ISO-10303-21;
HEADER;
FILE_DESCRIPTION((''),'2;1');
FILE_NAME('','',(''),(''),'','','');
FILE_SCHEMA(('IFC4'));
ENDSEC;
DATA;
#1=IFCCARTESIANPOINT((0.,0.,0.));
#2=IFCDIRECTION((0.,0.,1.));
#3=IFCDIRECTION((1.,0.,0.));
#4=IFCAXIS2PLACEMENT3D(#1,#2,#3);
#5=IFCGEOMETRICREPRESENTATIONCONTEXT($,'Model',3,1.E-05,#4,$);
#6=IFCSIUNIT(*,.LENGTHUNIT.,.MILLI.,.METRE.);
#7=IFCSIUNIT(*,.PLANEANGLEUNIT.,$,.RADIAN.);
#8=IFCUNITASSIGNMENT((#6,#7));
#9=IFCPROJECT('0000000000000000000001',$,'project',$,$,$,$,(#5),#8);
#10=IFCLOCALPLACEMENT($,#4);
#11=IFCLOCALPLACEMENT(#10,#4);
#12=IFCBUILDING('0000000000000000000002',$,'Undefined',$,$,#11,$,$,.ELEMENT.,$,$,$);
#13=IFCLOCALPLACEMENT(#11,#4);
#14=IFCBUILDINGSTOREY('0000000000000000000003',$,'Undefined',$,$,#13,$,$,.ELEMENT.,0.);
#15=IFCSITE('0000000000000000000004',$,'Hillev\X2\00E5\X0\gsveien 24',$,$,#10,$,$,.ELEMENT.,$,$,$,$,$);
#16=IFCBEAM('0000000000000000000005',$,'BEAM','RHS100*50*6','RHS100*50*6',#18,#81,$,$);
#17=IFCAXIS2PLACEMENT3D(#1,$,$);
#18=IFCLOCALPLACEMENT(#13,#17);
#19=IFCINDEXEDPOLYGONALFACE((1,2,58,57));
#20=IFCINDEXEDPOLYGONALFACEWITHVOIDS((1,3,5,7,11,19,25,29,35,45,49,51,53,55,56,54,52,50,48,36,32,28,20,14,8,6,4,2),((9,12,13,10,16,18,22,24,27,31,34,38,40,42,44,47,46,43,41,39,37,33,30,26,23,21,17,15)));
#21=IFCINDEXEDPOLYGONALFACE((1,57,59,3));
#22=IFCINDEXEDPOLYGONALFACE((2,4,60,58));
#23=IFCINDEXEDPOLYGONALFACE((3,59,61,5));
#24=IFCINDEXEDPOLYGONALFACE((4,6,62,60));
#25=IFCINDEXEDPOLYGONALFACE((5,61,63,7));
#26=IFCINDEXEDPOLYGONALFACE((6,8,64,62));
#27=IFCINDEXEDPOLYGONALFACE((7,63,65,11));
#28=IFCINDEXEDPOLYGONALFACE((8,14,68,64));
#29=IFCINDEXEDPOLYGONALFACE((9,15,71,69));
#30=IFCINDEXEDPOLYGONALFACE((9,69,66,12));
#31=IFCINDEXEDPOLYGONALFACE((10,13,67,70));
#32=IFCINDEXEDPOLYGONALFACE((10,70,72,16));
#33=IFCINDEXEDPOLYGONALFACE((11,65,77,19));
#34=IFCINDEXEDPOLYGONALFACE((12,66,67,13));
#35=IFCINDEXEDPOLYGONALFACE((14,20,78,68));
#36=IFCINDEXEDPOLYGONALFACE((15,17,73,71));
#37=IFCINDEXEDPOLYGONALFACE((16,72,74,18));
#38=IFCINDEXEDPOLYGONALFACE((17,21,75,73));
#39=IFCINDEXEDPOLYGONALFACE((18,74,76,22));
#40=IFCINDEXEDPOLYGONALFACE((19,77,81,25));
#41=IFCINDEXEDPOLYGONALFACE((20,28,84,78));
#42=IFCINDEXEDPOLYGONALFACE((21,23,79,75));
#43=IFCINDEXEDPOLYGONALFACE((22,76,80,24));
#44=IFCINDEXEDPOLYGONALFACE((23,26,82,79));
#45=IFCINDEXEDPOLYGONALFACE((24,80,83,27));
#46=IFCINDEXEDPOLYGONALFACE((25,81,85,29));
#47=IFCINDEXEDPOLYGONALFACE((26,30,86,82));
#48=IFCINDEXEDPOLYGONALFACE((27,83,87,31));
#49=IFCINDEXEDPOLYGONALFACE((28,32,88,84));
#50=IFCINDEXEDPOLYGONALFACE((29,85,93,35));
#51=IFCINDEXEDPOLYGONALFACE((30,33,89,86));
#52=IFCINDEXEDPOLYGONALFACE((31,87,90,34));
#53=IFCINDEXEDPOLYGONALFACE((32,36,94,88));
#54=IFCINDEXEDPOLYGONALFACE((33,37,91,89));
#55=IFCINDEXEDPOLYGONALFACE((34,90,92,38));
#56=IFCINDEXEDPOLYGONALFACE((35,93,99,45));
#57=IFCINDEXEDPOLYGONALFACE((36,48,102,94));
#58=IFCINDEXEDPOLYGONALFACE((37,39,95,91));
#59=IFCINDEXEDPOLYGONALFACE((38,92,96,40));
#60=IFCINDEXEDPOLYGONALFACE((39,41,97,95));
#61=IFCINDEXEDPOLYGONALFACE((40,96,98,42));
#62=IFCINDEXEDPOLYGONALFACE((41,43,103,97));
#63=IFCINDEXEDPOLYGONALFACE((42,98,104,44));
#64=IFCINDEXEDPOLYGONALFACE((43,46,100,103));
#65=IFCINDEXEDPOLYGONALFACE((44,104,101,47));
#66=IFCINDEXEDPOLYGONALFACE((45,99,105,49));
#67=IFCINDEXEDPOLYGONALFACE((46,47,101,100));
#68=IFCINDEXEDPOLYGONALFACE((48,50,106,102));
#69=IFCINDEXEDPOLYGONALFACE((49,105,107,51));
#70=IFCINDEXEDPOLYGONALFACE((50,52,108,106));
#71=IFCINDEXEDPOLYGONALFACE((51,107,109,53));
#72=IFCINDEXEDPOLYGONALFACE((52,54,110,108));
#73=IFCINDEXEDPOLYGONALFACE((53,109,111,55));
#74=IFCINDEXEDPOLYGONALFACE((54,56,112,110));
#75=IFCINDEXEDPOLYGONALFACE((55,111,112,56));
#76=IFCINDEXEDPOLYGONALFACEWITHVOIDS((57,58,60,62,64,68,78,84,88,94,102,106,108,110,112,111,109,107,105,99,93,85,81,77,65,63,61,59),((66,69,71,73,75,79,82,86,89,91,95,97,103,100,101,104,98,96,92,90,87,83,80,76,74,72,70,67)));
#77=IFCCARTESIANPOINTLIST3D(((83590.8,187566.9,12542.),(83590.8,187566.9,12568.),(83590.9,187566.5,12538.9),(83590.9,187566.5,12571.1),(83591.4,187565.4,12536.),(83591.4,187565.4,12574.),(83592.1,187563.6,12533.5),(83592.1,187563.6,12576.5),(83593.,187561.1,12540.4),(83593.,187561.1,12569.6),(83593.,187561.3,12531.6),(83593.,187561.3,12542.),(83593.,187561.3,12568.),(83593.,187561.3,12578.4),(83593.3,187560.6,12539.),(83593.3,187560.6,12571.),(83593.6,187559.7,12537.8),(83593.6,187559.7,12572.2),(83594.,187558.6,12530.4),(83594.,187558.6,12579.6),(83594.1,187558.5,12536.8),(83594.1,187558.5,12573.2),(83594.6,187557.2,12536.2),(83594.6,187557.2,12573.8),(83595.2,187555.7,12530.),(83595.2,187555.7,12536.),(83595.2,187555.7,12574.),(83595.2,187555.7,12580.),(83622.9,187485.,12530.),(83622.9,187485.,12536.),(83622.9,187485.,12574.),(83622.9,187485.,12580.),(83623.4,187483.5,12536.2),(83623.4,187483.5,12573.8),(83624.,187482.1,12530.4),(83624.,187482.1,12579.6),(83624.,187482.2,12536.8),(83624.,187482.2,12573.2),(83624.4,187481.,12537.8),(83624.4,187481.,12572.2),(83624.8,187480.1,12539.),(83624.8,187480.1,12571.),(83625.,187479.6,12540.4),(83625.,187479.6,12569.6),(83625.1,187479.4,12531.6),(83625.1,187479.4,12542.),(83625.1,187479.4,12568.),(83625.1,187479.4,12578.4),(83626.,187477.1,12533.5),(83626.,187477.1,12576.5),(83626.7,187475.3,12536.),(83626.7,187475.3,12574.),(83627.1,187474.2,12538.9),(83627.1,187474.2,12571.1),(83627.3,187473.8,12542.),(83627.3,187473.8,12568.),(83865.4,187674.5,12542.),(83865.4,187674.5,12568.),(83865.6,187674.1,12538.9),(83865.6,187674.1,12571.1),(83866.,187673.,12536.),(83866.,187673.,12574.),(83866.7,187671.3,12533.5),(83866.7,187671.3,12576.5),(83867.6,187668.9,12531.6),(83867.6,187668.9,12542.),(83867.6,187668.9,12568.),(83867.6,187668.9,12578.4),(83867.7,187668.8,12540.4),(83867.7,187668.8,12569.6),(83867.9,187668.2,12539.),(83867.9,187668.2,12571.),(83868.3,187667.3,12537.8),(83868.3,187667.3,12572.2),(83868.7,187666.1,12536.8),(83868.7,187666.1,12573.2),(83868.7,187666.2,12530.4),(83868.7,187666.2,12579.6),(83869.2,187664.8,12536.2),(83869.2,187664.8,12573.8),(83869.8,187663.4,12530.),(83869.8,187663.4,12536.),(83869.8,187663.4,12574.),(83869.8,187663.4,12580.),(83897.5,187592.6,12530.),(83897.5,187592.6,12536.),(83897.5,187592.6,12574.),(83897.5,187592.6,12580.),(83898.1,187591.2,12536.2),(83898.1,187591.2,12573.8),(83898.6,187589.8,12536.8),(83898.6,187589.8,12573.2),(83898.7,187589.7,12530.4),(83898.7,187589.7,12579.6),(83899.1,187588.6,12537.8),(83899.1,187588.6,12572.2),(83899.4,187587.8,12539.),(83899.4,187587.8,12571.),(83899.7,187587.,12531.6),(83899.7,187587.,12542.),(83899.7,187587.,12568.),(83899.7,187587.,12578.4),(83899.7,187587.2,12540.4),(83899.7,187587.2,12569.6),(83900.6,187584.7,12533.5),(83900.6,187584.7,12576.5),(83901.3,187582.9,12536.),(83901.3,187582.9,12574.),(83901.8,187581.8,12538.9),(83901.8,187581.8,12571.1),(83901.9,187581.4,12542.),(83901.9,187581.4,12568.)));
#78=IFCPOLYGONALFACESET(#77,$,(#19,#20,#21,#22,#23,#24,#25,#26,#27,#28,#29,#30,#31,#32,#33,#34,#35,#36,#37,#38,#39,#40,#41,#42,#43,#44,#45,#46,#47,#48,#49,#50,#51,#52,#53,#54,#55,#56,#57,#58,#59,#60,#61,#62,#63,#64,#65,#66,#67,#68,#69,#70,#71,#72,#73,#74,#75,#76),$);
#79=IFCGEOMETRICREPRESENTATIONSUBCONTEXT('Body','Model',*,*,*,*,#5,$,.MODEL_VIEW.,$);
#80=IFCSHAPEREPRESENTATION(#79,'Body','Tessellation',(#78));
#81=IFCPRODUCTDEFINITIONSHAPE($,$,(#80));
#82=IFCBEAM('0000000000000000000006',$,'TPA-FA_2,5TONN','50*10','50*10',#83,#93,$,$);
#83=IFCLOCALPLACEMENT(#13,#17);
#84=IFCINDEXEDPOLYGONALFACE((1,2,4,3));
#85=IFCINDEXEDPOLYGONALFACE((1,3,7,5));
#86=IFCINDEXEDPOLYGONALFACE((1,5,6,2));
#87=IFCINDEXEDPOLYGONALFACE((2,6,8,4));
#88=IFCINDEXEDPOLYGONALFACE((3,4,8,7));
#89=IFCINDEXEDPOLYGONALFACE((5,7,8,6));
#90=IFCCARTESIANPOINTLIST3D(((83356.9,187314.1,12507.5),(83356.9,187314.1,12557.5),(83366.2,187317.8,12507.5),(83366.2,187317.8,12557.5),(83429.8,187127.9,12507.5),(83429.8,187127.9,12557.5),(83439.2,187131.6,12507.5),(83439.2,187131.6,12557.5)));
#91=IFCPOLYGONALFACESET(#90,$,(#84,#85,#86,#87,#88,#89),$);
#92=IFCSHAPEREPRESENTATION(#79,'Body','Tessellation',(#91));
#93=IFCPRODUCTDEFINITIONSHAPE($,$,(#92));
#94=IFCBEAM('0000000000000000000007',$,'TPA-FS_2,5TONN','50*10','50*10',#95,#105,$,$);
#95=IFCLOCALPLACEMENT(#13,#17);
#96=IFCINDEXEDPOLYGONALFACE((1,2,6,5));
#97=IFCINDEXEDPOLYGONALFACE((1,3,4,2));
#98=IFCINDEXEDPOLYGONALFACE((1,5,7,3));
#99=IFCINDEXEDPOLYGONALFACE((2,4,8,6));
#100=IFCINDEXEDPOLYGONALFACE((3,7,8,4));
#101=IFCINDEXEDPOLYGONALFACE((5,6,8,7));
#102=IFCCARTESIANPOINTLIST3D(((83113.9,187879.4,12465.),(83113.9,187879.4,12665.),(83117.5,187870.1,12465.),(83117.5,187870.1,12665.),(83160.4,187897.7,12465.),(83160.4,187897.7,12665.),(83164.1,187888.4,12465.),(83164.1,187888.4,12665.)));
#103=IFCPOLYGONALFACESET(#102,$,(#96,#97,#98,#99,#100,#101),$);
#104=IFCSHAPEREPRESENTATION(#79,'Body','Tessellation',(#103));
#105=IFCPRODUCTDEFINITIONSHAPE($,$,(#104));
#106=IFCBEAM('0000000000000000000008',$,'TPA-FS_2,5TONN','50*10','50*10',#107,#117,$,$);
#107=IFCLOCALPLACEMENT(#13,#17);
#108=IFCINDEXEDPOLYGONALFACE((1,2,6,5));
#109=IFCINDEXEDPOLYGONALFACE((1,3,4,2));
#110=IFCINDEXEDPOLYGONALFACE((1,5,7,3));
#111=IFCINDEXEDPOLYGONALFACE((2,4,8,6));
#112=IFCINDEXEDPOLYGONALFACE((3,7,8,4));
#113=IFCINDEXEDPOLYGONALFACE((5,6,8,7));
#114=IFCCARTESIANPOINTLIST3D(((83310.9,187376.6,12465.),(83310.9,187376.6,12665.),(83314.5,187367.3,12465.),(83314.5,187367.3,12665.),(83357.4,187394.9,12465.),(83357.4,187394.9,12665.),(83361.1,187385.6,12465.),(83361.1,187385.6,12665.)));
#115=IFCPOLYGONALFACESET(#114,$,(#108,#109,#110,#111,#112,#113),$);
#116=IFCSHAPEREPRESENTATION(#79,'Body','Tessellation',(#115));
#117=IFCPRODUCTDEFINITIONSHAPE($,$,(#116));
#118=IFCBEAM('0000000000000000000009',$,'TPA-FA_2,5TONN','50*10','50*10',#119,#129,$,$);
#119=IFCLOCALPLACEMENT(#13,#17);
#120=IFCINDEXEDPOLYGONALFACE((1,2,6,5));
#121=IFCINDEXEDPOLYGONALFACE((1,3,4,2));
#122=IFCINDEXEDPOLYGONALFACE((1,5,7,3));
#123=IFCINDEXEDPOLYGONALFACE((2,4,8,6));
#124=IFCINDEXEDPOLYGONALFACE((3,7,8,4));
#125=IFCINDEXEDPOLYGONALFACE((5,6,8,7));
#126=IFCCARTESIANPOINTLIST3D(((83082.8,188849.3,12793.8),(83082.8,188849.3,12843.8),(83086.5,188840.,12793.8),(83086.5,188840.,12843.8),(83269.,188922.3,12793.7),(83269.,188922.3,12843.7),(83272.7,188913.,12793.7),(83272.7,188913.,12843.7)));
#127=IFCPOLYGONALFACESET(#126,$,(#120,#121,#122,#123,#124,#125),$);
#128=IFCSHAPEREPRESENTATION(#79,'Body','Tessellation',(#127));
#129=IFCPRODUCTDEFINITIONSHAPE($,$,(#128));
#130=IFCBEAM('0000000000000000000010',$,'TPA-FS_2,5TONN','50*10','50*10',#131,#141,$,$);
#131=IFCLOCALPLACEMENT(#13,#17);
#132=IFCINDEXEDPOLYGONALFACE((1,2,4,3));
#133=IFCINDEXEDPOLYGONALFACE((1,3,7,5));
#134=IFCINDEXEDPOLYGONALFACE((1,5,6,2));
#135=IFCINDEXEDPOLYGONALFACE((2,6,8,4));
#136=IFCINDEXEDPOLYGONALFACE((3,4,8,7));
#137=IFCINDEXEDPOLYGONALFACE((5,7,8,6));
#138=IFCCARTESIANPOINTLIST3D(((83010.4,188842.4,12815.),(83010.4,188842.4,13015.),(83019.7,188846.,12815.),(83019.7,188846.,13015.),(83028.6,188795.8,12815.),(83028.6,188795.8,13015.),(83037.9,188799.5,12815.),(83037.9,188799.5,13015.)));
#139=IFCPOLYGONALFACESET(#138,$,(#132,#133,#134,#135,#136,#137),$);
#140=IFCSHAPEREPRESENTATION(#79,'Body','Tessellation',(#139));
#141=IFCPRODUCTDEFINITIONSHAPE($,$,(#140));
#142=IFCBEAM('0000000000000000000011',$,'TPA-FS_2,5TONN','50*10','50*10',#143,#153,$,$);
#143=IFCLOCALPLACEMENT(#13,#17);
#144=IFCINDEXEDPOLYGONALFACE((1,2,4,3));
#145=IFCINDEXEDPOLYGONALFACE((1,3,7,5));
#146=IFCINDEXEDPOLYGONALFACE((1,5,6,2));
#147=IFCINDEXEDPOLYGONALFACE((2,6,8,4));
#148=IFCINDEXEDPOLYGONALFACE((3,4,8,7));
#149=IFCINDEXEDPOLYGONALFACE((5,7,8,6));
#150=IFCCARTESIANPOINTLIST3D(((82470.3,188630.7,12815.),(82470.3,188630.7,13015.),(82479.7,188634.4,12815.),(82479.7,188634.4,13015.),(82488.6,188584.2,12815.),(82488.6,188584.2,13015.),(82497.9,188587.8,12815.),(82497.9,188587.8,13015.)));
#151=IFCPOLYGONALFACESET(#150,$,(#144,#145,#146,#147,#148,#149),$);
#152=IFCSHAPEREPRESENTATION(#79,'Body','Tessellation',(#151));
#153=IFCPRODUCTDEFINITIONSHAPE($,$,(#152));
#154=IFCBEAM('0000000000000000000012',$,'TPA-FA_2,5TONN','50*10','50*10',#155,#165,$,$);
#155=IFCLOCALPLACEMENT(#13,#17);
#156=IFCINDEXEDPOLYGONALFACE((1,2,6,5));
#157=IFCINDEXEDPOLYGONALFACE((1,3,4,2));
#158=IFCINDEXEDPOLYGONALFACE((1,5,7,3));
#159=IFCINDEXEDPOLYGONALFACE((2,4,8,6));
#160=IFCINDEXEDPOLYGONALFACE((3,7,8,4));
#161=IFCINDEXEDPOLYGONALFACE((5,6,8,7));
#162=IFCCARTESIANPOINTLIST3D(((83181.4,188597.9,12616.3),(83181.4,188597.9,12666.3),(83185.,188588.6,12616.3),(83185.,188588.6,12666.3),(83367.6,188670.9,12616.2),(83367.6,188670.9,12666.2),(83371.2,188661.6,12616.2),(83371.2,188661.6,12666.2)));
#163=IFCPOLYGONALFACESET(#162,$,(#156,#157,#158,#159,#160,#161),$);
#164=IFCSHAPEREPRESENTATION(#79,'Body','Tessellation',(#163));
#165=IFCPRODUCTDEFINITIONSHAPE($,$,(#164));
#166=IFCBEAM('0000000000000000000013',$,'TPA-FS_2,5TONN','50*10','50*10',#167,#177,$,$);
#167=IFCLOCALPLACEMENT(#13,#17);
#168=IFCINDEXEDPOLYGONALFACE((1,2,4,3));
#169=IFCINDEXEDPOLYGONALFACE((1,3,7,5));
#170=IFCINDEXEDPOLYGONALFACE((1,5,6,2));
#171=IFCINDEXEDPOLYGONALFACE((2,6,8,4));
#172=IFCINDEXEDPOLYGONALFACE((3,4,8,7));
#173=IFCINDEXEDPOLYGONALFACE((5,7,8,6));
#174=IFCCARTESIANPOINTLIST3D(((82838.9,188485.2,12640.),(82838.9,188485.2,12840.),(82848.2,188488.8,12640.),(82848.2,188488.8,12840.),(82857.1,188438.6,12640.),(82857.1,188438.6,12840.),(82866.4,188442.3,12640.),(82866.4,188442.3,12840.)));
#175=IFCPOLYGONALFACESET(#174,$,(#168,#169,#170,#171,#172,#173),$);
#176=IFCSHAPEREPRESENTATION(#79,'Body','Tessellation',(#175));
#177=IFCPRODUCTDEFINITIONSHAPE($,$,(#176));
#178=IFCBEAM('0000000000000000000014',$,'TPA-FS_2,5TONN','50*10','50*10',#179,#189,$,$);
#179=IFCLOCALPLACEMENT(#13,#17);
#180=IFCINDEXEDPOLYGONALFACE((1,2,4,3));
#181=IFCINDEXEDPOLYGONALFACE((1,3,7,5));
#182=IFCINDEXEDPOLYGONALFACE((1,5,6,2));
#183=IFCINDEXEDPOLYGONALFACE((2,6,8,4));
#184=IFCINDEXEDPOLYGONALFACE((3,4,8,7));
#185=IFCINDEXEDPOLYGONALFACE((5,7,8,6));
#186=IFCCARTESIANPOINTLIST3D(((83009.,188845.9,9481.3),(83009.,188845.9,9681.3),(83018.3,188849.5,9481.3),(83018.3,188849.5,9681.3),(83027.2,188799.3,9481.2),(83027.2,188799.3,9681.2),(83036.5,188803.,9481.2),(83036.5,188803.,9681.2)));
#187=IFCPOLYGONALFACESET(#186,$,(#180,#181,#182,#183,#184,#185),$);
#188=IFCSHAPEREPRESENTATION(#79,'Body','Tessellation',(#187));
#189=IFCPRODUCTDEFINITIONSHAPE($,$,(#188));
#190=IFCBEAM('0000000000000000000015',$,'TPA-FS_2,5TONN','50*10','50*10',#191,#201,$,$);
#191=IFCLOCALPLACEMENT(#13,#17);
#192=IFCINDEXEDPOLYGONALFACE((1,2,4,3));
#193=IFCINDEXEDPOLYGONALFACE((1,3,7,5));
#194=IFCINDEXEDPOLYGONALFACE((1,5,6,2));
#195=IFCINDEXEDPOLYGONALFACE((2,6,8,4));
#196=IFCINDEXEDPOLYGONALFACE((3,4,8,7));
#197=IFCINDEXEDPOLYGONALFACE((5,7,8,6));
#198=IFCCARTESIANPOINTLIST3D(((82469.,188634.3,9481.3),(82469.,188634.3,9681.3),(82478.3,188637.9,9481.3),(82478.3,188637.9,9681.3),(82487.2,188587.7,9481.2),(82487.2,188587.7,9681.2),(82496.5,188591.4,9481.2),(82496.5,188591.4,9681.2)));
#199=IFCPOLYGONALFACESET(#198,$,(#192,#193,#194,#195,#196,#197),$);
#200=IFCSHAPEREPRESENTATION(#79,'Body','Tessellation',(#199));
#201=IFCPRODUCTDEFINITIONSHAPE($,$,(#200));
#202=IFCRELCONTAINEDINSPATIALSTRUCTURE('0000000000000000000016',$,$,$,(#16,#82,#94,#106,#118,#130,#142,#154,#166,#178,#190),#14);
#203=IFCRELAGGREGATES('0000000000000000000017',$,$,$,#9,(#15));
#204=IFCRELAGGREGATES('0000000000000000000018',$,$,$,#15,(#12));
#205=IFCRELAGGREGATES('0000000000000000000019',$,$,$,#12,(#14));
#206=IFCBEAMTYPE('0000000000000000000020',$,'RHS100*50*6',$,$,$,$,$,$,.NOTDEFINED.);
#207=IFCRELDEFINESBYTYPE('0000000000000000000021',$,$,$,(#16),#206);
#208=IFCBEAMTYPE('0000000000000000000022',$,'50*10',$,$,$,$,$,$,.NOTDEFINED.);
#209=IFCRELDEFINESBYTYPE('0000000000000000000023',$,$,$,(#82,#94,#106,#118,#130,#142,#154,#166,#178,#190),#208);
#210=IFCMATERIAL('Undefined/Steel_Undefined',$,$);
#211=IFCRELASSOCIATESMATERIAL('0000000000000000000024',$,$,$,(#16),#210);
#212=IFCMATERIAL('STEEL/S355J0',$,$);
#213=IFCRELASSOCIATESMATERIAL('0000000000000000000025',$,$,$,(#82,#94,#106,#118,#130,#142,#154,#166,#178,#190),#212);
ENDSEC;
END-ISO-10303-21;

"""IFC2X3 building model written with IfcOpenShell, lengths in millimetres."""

from ifc_helpers import new_model, si_unit, frame, frame_2d, origin_with_axes, place, context, subcontext, project, spatial, rectangle, hollow_rectangle, extrude, material, type_object, element, save


model = new_model("IFC2X3")

# Units and contexts
model_context = context("Model", 3, precision=1e-05, world=origin_with_axes())
body_context = subcontext(model_context, "Body", "Model", "MODEL_VIEW")
ifc_project = project(units=[si_unit("LENGTHUNIT", "METRE", prefix="MILLI"), si_unit("PLANEANGLEUNIT", "RADIAN")], contexts=[model_context])

# Site, building, storey
site_placement = place(None, origin_with_axes())
site = spatial("IfcSite", under=ifc_project, at=site_placement, Name="Hillevågsveien 24", CompositionType="ELEMENT")
building_placement = place(site_placement, origin_with_axes())
building = spatial("IfcBuilding", under=site, at=building_placement, Name="Undefined", CompositionType="ELEMENT")
storey_placement = place(building_placement, origin_with_axes())
storey = spatial("IfcBuildingStorey", under=building, at=storey_placement, Name="Undefined", CompositionType="ELEMENT", Elevation=0.0)

# Beams
ifc_material_1 = material(Name="Undefined/Steel_Undefined")
beam_type_1 = type_object("IfcBeamType", Name="RHS100*50*6", PredefinedType="NOTDEFINED")
for number, where, z_axis, x_axis, name in (
    (1, (83883.7, 187628.0, 12555.0), (0.364877, -0.931056, 0.0), (-0.931056, -0.364877, 0.0), "BEAM"),
):
    element("IfcBeam", number, at=place(storey_placement, frame(where, z_axis=z_axis, x_axis=x_axis)), inside=storey, type_object=beam_type_1, material=ifc_material_1, Name=name, Description="RHS100*50*6", ObjectType="RHS100*50*6", context=body_context, shape_type="SweptSolid", body=[
        extrude(hollow_rectangle(XDim=50.0, YDim=100.0, WallThickness=6.0, InnerFilletRadius=6.0, OuterFilletRadius=12.0, at=frame_2d((0.0, 0.0), x_axis=(1.0, 0.0))), frame((295.0, 0.0, 0.0), z_axis=(-1.0, 0.0, 0.0), x_axis=(0.0, -1.0, 0.0)), (0.0, 0.0, 1.0), 295.0),
    ])
ifc_material_2 = material(Name="STEEL/S355J0")
beam_type_2 = type_object("IfcBeamType", Name="50*10", PredefinedType="NOTDEFINED")
beam_1_placement = place(storey_placement, frame((83434.5, 187129.7, 12532.5), z_axis=(-0.000005, 0.000012, 1.0), x_axis=(-0.364877, 0.931056, -0.000013)))
element("IfcBeam", 2, at=beam_1_placement, inside=storey, type_object=beam_type_2, material=ifc_material_2, Name="TPA-FA_2,5TONN", Description="50*10", ObjectType="50*10", context=body_context, shape_type="SweptSolid", body=[
    extrude(rectangle(XDim=10.0, YDim=50.0, at=frame_2d((0.0, 0.0), x_axis=(1.0, 0.0))), frame((200.0, 0.0, 0.0), z_axis=(-1.0, 0.0, 0.0), x_axis=(0.0, -1.0, 0.0)), (0.0, 0.0, 1.0), 200.0),
])
for number, where, z_axis, x_axis, name in (
    (3, (83139.0, 187883.9, 12665.0), (0.931056, 0.364877, 0.0), (0.0, 0.0, -1.0), "TPA-FS_2,5TONN"),
    (4, (83336.0, 187381.1, 12665.0), (0.931056, 0.364877, 0.0), (0.0, 0.0, -1.0), "TPA-FS_2,5TONN"),
):
    element("IfcBeam", number, at=place(storey_placement, frame(where, z_axis=z_axis, x_axis=x_axis)), inside=storey, type_object=beam_type_2, material=ifc_material_2, Name=name, Description="50*10", ObjectType="50*10", context=body_context, shape_type="SweptSolid", body=[
        extrude(rectangle(XDim=10.0, YDim=50.0, at=frame_2d((0.0, 0.0), x_axis=(1.0, 0.0))), frame((200.0, 0.0, 0.0), z_axis=(-1.0, 0.0, 0.0), x_axis=(0.0, -1.0, 0.0)), (0.0, 0.0, 1.0), 200.0),
    ])
beam_2_placement = place(storey_placement, frame((83270.9, 188917.6, 12818.7), z_axis=(0.000001, 0.0, 1.0), x_axis=(-0.931056, -0.364877, 0.000001)))
element("IfcBeam", 5, at=beam_2_placement, inside=storey, type_object=beam_type_2, material=ifc_material_2, Name="TPA-FA_2,5TONN", Description="50*10", ObjectType="50*10", context=body_context, shape_type="SweptSolid", body=[
    extrude(rectangle(XDim=10.0, YDim=50.0, at=frame_2d((0.0, 0.0), x_axis=(1.0, 0.0))), frame((200.0, 0.0, 0.0), z_axis=(-1.0, 0.0, 0.0), x_axis=(0.0, -1.0, 0.0)), (0.0, 0.0, 1.0), 200.0),
])
for number, where, z_axis, x_axis, name in (
    (6, (83024.1, 188820.9, 13015.0), (-0.364877, 0.931056, 0.0), (0.0, 0.0, -1.0), "TPA-FS_2,5TONN"),
    (7, (82484.1, 188609.3, 13015.0), (-0.364877, 0.931056, 0.0), (0.0, 0.0, -1.0), "TPA-FS_2,5TONN"),
):
    element("IfcBeam", number, at=place(storey_placement, frame(where, z_axis=z_axis, x_axis=x_axis)), inside=storey, type_object=beam_type_2, material=ifc_material_2, Name=name, Description="50*10", ObjectType="50*10", context=body_context, shape_type="SweptSolid", body=[
        extrude(rectangle(XDim=10.0, YDim=50.0, at=frame_2d((0.0, 0.0), x_axis=(1.0, 0.0))), frame((200.0, 0.0, 0.0), z_axis=(-1.0, 0.0, 0.0), x_axis=(0.0, -1.0, 0.0)), (0.0, 0.0, 1.0), 200.0),
    ])
beam_3_placement = place(storey_placement, frame((83369.4, 188666.2, 12641.2), z_axis=(0.000001, 0.0, 1.0), x_axis=(-0.931056, -0.364877, 0.000001)))
element("IfcBeam", 8, at=beam_3_placement, inside=storey, type_object=beam_type_2, material=ifc_material_2, Name="TPA-FA_2,5TONN", Description="50*10", ObjectType="50*10", context=body_context, shape_type="SweptSolid", body=[
    extrude(rectangle(XDim=10.0, YDim=50.0, at=frame_2d((0.0, 0.0), x_axis=(1.0, 0.0))), frame((200.0, 0.0, 0.0), z_axis=(-1.0, 0.0, 0.0), x_axis=(0.0, -1.0, 0.0)), (0.0, 0.0, 1.0), 200.0),
])
for number, where, z_axis, x_axis, name in (
    (9, (82852.6, 188463.7, 12840.0), (-0.364877, 0.931056, 0.0), (0.0, 0.0, -1.0), "TPA-FS_2,5TONN"),
    (10, (83022.8, 188824.4, 9681.2), (-0.364877, 0.931056, 0.0), (0.0, 0.0, -1.0), "TPA-FS_2,5TONN"),
    (11, (82482.7, 188612.8, 9681.2), (-0.364877, 0.931056, 0.0), (0.0, 0.0, -1.0), "TPA-FS_2,5TONN"),
):
    element("IfcBeam", number, at=place(storey_placement, frame(where, z_axis=z_axis, x_axis=x_axis)), inside=storey, type_object=beam_type_2, material=ifc_material_2, Name=name, Description="50*10", ObjectType="50*10", context=body_context, shape_type="SweptSolid", body=[
        extrude(rectangle(XDim=10.0, YDim=50.0, at=frame_2d((0.0, 0.0), x_axis=(1.0, 0.0))), frame((200.0, 0.0, 0.0), z_axis=(-1.0, 0.0, 0.0), x_axis=(0.0, -1.0, 0.0)), (0.0, 0.0, 1.0), 200.0),
    ])

save(model, "model.ifc")
